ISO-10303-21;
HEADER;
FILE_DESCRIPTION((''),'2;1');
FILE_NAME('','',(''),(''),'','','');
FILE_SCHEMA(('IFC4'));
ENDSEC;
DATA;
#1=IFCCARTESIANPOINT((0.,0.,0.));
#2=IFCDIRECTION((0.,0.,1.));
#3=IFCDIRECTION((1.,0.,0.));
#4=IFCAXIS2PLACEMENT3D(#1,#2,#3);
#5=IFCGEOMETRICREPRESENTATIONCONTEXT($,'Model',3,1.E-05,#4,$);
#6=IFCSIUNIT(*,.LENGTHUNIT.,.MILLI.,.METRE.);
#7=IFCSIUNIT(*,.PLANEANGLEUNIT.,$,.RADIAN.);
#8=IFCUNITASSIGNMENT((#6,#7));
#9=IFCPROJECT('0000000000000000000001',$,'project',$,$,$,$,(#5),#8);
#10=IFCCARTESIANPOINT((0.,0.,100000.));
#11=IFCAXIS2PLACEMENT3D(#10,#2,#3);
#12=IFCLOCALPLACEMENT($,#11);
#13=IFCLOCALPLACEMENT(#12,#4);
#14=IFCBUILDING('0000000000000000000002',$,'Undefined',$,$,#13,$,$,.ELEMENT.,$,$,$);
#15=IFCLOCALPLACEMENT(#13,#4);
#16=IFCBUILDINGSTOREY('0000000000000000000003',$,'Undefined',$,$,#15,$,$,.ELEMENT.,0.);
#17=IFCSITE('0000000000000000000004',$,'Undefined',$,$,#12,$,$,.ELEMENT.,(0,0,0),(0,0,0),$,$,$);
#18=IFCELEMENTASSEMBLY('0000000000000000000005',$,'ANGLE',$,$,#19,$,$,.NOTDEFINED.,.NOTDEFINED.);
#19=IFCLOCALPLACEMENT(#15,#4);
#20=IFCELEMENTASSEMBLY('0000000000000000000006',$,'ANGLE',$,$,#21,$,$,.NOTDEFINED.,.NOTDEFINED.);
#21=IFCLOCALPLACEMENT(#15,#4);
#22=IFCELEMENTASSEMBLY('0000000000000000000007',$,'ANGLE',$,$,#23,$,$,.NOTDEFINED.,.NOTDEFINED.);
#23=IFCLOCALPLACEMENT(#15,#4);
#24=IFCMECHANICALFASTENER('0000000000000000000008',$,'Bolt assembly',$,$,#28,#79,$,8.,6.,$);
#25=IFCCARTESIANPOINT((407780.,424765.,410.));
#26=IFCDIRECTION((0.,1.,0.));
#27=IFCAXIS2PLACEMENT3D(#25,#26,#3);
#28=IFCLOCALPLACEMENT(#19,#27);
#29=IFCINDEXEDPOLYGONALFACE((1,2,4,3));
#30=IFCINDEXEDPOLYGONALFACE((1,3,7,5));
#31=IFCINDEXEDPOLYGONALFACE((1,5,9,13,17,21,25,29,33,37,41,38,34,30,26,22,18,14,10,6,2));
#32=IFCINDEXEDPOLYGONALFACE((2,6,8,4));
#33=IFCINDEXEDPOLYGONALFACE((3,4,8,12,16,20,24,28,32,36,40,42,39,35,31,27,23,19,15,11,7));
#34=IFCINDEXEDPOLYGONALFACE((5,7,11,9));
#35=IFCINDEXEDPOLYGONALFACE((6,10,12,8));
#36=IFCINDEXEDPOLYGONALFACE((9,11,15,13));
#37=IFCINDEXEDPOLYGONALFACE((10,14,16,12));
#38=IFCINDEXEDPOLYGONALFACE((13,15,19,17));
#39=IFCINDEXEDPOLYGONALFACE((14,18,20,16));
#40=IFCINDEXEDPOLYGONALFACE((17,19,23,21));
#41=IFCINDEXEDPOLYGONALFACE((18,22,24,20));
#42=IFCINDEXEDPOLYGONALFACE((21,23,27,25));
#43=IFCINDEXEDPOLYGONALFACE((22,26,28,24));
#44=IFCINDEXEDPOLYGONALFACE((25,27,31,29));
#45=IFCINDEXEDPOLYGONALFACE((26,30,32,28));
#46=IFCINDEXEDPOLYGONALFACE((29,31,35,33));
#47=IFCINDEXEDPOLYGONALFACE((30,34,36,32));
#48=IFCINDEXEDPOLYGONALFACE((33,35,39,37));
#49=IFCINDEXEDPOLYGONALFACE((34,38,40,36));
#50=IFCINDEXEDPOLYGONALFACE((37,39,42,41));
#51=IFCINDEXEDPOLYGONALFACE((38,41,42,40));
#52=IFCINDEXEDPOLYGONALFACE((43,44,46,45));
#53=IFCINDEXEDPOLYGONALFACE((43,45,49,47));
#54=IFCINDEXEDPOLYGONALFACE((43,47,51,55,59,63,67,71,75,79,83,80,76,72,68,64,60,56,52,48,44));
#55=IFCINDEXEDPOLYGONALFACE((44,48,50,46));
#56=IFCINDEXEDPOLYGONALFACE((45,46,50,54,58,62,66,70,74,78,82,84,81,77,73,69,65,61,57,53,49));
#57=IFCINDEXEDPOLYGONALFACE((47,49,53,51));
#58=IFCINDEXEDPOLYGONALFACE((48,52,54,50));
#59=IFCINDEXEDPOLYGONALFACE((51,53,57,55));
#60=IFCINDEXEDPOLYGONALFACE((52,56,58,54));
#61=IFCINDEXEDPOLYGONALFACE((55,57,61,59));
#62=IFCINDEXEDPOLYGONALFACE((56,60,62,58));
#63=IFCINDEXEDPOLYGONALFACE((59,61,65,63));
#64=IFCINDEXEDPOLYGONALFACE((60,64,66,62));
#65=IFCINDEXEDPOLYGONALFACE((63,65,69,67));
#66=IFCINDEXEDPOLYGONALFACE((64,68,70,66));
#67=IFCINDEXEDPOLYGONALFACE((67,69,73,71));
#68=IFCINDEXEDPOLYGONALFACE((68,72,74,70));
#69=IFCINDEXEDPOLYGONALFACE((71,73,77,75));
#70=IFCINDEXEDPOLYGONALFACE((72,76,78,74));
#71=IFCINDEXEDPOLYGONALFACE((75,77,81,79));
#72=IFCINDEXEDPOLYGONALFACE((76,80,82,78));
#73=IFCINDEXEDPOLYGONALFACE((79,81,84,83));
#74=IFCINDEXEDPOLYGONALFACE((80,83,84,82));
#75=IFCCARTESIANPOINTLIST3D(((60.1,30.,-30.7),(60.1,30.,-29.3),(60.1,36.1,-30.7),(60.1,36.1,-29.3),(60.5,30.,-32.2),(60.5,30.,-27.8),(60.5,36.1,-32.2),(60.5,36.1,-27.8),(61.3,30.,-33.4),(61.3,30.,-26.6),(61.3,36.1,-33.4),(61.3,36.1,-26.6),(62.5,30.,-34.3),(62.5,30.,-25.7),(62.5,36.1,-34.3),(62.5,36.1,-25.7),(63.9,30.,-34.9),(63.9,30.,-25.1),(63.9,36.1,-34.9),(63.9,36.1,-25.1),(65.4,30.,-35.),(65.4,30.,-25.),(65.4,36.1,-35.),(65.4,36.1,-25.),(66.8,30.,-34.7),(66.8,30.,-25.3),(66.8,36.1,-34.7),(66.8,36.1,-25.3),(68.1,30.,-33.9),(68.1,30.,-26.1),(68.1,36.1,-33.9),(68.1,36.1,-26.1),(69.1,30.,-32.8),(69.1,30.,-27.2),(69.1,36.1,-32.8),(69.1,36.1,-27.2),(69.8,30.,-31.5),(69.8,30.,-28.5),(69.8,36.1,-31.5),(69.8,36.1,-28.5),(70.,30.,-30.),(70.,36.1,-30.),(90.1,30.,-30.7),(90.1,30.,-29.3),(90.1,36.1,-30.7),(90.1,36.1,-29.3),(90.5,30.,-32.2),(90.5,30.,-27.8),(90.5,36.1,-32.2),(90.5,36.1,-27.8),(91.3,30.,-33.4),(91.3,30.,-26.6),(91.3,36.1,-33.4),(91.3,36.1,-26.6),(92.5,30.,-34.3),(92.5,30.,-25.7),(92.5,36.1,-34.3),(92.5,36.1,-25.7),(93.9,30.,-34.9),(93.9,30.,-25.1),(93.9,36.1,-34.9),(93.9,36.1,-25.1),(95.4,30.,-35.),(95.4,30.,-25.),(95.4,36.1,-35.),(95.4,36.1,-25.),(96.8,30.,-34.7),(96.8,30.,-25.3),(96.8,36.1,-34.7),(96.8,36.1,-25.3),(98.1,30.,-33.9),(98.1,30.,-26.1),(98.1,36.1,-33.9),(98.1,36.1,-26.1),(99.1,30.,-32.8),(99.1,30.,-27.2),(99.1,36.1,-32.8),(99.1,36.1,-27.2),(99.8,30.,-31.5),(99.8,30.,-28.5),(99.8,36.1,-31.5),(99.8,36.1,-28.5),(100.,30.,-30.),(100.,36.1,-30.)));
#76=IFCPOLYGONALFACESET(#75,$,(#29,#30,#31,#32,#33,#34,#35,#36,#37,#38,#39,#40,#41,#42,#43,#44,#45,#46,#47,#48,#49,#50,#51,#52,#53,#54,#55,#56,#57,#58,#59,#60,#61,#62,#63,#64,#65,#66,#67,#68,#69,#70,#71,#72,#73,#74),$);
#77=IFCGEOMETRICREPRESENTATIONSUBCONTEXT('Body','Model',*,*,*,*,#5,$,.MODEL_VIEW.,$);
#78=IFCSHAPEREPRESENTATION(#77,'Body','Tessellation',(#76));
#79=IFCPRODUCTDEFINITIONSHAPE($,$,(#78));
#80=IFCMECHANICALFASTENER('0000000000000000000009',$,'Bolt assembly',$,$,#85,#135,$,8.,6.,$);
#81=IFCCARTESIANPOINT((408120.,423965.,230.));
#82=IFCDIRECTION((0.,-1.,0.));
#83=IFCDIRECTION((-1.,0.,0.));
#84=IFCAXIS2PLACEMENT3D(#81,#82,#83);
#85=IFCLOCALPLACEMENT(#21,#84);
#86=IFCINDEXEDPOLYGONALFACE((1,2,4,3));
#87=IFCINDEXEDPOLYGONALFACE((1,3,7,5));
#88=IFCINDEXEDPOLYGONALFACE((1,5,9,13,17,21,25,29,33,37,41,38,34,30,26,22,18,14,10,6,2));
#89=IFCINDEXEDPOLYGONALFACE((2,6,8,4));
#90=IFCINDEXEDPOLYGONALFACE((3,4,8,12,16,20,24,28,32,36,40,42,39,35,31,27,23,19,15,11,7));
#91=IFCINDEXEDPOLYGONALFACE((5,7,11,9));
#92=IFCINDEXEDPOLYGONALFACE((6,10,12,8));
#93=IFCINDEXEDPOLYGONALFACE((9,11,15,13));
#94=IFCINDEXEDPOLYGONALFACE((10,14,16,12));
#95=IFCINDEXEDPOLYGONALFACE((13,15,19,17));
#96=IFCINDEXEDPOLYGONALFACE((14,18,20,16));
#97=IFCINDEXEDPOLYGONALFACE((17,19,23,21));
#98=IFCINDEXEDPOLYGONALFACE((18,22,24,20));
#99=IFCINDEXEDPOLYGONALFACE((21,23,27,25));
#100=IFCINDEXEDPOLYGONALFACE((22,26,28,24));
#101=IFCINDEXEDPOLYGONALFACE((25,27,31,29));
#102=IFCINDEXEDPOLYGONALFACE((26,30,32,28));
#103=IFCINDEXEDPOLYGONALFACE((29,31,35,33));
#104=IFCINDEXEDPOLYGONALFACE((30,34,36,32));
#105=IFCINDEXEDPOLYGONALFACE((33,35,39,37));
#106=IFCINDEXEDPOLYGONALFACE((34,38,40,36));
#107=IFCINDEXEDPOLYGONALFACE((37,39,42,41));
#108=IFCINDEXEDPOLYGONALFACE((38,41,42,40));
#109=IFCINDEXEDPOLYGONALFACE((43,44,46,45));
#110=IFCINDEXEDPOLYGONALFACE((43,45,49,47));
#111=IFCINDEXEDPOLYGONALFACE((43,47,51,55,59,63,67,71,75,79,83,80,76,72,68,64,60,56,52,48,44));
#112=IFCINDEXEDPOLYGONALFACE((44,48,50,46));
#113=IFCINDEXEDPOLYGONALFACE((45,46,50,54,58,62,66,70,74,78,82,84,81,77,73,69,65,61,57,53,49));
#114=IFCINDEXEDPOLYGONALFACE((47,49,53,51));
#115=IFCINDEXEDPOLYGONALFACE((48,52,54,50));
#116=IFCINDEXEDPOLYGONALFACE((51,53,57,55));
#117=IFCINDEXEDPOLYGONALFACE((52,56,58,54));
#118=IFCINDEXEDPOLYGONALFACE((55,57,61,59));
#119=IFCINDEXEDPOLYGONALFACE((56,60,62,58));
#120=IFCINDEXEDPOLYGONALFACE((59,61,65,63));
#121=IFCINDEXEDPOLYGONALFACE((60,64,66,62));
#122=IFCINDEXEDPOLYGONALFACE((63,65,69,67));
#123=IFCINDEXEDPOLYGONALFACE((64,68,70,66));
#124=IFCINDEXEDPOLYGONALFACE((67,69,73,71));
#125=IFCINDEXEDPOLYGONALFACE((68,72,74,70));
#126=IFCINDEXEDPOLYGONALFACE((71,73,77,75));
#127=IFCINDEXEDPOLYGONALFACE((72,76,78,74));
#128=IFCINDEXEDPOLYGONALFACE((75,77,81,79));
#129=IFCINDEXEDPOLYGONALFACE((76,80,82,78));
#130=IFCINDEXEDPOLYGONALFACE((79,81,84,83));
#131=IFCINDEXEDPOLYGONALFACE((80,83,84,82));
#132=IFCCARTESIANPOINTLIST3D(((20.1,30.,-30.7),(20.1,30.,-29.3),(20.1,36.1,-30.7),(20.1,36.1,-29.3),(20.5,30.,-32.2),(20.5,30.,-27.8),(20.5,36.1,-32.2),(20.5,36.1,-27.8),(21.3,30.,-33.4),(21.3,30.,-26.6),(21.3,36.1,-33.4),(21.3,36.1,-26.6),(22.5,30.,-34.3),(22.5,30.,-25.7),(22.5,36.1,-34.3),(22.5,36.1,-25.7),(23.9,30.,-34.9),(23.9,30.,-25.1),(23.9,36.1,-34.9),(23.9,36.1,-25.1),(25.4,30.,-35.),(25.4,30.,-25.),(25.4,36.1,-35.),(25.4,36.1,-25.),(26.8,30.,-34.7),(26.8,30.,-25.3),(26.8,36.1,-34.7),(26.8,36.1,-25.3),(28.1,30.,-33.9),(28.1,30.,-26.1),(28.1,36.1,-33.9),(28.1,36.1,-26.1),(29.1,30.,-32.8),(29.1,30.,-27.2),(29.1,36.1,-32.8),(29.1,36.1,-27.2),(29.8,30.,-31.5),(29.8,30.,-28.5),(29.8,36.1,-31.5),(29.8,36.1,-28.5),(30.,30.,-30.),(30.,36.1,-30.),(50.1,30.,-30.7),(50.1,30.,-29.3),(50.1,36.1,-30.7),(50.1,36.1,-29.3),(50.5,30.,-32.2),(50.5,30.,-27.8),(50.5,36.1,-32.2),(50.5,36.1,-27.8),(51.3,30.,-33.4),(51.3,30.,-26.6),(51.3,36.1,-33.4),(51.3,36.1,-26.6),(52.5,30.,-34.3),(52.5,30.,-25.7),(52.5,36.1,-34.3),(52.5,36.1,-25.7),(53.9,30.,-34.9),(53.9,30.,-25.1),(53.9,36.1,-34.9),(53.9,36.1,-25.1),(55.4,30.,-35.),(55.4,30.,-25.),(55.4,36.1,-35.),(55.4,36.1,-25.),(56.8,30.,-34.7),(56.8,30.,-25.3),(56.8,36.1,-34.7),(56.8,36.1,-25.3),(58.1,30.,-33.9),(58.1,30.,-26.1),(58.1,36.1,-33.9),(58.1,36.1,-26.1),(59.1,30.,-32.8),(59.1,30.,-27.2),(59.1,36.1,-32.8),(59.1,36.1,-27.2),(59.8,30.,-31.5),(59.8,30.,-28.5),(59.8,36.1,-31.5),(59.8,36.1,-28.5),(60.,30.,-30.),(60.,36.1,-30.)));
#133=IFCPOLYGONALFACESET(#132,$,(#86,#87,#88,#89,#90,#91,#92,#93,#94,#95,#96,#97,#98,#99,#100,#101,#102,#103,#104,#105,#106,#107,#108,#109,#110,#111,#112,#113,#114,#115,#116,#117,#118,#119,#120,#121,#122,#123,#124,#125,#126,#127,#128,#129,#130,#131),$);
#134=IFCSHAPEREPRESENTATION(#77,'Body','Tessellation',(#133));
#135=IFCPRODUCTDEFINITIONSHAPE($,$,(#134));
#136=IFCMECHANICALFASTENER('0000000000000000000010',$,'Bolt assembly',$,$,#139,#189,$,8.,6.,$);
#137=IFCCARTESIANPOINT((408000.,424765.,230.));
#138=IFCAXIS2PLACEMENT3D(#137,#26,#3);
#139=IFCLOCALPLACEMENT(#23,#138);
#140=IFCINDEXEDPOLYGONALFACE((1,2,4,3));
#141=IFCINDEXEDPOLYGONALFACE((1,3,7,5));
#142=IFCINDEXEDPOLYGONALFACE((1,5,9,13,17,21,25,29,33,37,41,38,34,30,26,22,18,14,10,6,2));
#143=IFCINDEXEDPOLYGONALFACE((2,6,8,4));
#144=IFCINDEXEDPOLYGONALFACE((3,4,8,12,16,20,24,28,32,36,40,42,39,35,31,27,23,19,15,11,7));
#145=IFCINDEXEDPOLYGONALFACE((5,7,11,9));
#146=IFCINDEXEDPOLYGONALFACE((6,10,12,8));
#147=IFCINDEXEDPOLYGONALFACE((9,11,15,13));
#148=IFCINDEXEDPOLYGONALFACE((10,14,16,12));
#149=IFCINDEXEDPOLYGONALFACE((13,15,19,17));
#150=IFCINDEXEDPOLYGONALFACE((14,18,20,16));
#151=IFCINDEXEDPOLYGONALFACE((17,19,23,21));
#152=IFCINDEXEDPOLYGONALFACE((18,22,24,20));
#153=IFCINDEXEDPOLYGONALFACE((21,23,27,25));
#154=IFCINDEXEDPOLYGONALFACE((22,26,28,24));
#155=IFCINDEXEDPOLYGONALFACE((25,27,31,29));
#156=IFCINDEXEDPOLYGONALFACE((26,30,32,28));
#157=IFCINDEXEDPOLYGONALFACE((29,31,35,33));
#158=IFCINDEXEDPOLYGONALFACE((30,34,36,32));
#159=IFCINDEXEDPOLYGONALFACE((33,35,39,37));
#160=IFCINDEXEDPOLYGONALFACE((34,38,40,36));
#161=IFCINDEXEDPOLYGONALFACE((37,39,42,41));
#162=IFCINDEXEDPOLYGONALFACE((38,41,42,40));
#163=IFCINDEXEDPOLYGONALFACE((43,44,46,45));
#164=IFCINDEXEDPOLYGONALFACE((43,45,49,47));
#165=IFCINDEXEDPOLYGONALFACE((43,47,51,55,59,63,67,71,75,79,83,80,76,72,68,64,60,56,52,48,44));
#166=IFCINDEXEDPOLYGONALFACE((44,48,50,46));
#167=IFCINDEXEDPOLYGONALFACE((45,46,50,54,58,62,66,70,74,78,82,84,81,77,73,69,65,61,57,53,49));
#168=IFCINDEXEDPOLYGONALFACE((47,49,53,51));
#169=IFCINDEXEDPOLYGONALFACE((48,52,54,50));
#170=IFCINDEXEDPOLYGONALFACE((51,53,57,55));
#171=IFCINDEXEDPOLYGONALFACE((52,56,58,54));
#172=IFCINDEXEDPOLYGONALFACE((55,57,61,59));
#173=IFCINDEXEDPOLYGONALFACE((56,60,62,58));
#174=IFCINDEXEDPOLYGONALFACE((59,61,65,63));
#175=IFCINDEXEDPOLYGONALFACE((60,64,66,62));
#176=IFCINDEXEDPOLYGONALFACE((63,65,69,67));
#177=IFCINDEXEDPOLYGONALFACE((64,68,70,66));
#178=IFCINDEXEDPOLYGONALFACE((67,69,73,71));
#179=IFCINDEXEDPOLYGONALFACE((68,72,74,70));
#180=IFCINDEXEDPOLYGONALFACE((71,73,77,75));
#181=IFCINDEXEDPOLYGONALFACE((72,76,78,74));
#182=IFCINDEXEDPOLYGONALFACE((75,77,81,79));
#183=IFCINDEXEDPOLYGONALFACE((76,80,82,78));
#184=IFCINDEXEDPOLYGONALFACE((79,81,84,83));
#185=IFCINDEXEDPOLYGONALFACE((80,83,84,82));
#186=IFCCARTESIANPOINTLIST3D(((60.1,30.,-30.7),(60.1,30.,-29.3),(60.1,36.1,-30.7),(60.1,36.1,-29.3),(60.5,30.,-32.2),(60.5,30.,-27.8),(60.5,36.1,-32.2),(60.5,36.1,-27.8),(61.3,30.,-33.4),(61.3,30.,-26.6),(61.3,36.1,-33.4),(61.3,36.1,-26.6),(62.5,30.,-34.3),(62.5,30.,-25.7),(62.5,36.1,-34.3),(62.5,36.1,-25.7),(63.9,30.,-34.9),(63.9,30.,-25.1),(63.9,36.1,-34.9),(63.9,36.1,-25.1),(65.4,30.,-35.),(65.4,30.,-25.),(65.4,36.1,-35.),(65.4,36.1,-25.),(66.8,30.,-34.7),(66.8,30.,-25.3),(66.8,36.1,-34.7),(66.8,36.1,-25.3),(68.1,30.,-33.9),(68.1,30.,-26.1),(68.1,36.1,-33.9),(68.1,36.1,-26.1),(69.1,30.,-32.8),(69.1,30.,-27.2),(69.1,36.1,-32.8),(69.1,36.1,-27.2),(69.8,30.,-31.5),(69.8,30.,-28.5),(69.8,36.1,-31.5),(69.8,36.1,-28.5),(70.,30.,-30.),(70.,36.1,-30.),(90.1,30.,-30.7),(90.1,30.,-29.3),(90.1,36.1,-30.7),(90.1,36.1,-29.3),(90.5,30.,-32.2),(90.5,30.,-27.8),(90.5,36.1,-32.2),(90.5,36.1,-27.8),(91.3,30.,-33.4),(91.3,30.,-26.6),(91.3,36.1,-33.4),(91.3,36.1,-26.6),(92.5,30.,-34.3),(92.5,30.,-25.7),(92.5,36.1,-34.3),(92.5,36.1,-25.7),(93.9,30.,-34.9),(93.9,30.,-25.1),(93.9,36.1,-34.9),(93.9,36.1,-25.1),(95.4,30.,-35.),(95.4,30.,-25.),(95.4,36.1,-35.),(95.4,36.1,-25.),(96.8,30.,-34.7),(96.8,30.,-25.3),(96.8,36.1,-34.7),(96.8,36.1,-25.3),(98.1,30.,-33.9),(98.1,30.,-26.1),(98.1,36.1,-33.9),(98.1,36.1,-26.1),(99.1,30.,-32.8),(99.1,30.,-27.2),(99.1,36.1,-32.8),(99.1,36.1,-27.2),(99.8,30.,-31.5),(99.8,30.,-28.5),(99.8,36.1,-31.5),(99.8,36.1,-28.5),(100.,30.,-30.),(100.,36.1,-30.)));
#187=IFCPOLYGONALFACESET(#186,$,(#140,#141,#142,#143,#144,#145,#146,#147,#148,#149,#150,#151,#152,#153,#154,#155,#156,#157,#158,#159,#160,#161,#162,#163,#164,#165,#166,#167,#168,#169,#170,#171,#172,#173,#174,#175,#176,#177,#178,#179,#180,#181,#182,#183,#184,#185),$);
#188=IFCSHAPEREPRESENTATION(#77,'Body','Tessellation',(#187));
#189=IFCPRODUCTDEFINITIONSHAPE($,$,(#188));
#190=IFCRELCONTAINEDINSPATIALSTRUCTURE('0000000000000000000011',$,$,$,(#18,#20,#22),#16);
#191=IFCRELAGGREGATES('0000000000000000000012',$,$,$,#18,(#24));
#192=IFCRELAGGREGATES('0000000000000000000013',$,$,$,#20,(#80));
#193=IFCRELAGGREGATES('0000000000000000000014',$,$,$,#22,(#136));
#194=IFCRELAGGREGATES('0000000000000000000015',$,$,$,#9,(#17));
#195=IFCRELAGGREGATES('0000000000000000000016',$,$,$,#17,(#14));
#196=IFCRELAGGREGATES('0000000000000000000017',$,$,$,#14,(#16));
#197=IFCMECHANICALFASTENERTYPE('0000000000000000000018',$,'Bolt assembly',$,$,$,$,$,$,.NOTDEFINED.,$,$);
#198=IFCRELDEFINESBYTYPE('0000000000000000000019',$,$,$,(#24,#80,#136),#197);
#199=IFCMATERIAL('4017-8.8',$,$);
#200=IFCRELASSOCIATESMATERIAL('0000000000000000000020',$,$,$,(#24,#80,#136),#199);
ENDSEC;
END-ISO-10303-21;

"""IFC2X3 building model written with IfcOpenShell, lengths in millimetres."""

from ifc_helpers import new_model, si_unit, frame, origin_with_axes, origin_2d_with_axis, place, context, subcontext, project, spatial, circle, extrude, source, transform, mapped, material, type_object, element, aggregate, save


model = new_model("IFC2X3")

# Units and contexts
model_context = context("Model", 3, precision=1e-05, world=origin_with_axes())
body_context = subcontext(model_context, "Body", "Model", "MODEL_VIEW")
ifc_project = project(units=[si_unit("LENGTHUNIT", "METRE", prefix="MILLI"), si_unit("PLANEANGLEUNIT", "RADIAN")], contexts=[model_context])

# Site, building, storey
site_placement = place(None, frame((0.0, 0.0, 100000.0), z_axis=(0.0, 0.0, 1.0), x_axis=(1.0, 0.0, 0.0)))
site = spatial("IfcSite", under=ifc_project, at=site_placement, Name="Undefined", CompositionType="ELEMENT", RefLatitude=(0, 0, 0), RefLongitude=(0, 0, 0))
building_placement = place(site_placement, origin_with_axes())
building = spatial("IfcBuilding", under=site, at=building_placement, Name="Undefined", CompositionType="ELEMENT")
storey_placement = place(building_placement, origin_with_axes())
storey = spatial("IfcBuildingStorey", under=building, at=storey_placement, Name="Undefined", CompositionType="ELEMENT", Elevation=0.0)

# Element assemblies
assembly_1_placement = place(storey_placement, origin_with_axes())
assembly_1 = element("IfcElementAssembly", 1, at=assembly_1_placement, inside=storey, Name="ANGLE", AssemblyPlace="NOTDEFINED", PredefinedType="NOTDEFINED")
assembly_2_placement = place(storey_placement, origin_with_axes())
assembly_2 = element("IfcElementAssembly", 2, at=assembly_2_placement, inside=storey, Name="ANGLE", AssemblyPlace="NOTDEFINED", PredefinedType="NOTDEFINED")
assembly_3_placement = place(storey_placement, origin_with_axes())
assembly_3 = element("IfcElementAssembly", 3, at=assembly_3_placement, inside=storey, Name="ANGLE", AssemblyPlace="NOTDEFINED", PredefinedType="NOTDEFINED")

# Shared definitions
ifc_material_1 = material(Name="4017-8.8")
mechanical_fastener_type = type_object("IfcMechanicalFastenerType", Name="Bolt assembly")

# Mechanical fasteners
shared_shape_1 = source(origin_with_axes(), body_context, "Body", "SweptSolid", [
    extrude(circle(Radius=5.0, at=origin_2d_with_axis()), frame((0.0, 30.0, 0.0), z_axis=(0.0, 1.0, 0.0), x_axis=(1.0, 0.0, 0.0)), (0.0, 0.0, 1.0), 6.1),
])
mechanical_fastener_1_placement = place(assembly_1_placement, frame((407780.0, 424765.0, 410.0), z_axis=(0.0, 1.0, 0.0), x_axis=(1.0, 0.0, 0.0)))
mechanical_fastener_1 = element("IfcMechanicalFastener", 4, at=mechanical_fastener_1_placement, type_object=mechanical_fastener_type, material=ifc_material_1, Name="Bolt assembly", NominalDiameter=8.0, NominalLength=6.0, context=body_context, shape_type="MappedRepresentation", body=[
    mapped(shared_shape_1, transform((95.0, 0.0, -30.0))),
    mapped(shared_shape_1, transform((65.0, 0.0, -30.0))),
])
aggregate(assembly_1, [mechanical_fastener_1])
mechanical_fastener_2_placement = place(assembly_2_placement, frame((408120.0, 423965.0, 230.0), z_axis=(0.0, -1.0, 0.0), x_axis=(-1.0, 0.0, 0.0)))
mechanical_fastener_2 = element("IfcMechanicalFastener", 5, at=mechanical_fastener_2_placement, type_object=mechanical_fastener_type, material=ifc_material_1, Name="Bolt assembly", NominalDiameter=8.0, NominalLength=6.0, context=body_context, shape_type="MappedRepresentation", body=[
    mapped(shared_shape_1, transform((25.0, 0.0, -30.0))),
    mapped(shared_shape_1, transform((55.0, 0.0, -30.0))),
])
aggregate(assembly_2, [mechanical_fastener_2])
mechanical_fastener_3_placement = place(assembly_3_placement, frame((408000.0, 424765.0, 230.0), z_axis=(0.0, 1.0, 0.0), x_axis=(1.0, 0.0, 0.0)))
mechanical_fastener_3 = element("IfcMechanicalFastener", 6, at=mechanical_fastener_3_placement, type_object=mechanical_fastener_type, material=ifc_material_1, Name="Bolt assembly", NominalDiameter=8.0, NominalLength=6.0, context=body_context, shape_type="MappedRepresentation", body=[
    mapped(shared_shape_1, transform((95.0, 0.0, -30.0))),
    mapped(shared_shape_1, transform((65.0, 0.0, -30.0))),
])
aggregate(assembly_3, [mechanical_fastener_3])

save(model, "model.ifc")
